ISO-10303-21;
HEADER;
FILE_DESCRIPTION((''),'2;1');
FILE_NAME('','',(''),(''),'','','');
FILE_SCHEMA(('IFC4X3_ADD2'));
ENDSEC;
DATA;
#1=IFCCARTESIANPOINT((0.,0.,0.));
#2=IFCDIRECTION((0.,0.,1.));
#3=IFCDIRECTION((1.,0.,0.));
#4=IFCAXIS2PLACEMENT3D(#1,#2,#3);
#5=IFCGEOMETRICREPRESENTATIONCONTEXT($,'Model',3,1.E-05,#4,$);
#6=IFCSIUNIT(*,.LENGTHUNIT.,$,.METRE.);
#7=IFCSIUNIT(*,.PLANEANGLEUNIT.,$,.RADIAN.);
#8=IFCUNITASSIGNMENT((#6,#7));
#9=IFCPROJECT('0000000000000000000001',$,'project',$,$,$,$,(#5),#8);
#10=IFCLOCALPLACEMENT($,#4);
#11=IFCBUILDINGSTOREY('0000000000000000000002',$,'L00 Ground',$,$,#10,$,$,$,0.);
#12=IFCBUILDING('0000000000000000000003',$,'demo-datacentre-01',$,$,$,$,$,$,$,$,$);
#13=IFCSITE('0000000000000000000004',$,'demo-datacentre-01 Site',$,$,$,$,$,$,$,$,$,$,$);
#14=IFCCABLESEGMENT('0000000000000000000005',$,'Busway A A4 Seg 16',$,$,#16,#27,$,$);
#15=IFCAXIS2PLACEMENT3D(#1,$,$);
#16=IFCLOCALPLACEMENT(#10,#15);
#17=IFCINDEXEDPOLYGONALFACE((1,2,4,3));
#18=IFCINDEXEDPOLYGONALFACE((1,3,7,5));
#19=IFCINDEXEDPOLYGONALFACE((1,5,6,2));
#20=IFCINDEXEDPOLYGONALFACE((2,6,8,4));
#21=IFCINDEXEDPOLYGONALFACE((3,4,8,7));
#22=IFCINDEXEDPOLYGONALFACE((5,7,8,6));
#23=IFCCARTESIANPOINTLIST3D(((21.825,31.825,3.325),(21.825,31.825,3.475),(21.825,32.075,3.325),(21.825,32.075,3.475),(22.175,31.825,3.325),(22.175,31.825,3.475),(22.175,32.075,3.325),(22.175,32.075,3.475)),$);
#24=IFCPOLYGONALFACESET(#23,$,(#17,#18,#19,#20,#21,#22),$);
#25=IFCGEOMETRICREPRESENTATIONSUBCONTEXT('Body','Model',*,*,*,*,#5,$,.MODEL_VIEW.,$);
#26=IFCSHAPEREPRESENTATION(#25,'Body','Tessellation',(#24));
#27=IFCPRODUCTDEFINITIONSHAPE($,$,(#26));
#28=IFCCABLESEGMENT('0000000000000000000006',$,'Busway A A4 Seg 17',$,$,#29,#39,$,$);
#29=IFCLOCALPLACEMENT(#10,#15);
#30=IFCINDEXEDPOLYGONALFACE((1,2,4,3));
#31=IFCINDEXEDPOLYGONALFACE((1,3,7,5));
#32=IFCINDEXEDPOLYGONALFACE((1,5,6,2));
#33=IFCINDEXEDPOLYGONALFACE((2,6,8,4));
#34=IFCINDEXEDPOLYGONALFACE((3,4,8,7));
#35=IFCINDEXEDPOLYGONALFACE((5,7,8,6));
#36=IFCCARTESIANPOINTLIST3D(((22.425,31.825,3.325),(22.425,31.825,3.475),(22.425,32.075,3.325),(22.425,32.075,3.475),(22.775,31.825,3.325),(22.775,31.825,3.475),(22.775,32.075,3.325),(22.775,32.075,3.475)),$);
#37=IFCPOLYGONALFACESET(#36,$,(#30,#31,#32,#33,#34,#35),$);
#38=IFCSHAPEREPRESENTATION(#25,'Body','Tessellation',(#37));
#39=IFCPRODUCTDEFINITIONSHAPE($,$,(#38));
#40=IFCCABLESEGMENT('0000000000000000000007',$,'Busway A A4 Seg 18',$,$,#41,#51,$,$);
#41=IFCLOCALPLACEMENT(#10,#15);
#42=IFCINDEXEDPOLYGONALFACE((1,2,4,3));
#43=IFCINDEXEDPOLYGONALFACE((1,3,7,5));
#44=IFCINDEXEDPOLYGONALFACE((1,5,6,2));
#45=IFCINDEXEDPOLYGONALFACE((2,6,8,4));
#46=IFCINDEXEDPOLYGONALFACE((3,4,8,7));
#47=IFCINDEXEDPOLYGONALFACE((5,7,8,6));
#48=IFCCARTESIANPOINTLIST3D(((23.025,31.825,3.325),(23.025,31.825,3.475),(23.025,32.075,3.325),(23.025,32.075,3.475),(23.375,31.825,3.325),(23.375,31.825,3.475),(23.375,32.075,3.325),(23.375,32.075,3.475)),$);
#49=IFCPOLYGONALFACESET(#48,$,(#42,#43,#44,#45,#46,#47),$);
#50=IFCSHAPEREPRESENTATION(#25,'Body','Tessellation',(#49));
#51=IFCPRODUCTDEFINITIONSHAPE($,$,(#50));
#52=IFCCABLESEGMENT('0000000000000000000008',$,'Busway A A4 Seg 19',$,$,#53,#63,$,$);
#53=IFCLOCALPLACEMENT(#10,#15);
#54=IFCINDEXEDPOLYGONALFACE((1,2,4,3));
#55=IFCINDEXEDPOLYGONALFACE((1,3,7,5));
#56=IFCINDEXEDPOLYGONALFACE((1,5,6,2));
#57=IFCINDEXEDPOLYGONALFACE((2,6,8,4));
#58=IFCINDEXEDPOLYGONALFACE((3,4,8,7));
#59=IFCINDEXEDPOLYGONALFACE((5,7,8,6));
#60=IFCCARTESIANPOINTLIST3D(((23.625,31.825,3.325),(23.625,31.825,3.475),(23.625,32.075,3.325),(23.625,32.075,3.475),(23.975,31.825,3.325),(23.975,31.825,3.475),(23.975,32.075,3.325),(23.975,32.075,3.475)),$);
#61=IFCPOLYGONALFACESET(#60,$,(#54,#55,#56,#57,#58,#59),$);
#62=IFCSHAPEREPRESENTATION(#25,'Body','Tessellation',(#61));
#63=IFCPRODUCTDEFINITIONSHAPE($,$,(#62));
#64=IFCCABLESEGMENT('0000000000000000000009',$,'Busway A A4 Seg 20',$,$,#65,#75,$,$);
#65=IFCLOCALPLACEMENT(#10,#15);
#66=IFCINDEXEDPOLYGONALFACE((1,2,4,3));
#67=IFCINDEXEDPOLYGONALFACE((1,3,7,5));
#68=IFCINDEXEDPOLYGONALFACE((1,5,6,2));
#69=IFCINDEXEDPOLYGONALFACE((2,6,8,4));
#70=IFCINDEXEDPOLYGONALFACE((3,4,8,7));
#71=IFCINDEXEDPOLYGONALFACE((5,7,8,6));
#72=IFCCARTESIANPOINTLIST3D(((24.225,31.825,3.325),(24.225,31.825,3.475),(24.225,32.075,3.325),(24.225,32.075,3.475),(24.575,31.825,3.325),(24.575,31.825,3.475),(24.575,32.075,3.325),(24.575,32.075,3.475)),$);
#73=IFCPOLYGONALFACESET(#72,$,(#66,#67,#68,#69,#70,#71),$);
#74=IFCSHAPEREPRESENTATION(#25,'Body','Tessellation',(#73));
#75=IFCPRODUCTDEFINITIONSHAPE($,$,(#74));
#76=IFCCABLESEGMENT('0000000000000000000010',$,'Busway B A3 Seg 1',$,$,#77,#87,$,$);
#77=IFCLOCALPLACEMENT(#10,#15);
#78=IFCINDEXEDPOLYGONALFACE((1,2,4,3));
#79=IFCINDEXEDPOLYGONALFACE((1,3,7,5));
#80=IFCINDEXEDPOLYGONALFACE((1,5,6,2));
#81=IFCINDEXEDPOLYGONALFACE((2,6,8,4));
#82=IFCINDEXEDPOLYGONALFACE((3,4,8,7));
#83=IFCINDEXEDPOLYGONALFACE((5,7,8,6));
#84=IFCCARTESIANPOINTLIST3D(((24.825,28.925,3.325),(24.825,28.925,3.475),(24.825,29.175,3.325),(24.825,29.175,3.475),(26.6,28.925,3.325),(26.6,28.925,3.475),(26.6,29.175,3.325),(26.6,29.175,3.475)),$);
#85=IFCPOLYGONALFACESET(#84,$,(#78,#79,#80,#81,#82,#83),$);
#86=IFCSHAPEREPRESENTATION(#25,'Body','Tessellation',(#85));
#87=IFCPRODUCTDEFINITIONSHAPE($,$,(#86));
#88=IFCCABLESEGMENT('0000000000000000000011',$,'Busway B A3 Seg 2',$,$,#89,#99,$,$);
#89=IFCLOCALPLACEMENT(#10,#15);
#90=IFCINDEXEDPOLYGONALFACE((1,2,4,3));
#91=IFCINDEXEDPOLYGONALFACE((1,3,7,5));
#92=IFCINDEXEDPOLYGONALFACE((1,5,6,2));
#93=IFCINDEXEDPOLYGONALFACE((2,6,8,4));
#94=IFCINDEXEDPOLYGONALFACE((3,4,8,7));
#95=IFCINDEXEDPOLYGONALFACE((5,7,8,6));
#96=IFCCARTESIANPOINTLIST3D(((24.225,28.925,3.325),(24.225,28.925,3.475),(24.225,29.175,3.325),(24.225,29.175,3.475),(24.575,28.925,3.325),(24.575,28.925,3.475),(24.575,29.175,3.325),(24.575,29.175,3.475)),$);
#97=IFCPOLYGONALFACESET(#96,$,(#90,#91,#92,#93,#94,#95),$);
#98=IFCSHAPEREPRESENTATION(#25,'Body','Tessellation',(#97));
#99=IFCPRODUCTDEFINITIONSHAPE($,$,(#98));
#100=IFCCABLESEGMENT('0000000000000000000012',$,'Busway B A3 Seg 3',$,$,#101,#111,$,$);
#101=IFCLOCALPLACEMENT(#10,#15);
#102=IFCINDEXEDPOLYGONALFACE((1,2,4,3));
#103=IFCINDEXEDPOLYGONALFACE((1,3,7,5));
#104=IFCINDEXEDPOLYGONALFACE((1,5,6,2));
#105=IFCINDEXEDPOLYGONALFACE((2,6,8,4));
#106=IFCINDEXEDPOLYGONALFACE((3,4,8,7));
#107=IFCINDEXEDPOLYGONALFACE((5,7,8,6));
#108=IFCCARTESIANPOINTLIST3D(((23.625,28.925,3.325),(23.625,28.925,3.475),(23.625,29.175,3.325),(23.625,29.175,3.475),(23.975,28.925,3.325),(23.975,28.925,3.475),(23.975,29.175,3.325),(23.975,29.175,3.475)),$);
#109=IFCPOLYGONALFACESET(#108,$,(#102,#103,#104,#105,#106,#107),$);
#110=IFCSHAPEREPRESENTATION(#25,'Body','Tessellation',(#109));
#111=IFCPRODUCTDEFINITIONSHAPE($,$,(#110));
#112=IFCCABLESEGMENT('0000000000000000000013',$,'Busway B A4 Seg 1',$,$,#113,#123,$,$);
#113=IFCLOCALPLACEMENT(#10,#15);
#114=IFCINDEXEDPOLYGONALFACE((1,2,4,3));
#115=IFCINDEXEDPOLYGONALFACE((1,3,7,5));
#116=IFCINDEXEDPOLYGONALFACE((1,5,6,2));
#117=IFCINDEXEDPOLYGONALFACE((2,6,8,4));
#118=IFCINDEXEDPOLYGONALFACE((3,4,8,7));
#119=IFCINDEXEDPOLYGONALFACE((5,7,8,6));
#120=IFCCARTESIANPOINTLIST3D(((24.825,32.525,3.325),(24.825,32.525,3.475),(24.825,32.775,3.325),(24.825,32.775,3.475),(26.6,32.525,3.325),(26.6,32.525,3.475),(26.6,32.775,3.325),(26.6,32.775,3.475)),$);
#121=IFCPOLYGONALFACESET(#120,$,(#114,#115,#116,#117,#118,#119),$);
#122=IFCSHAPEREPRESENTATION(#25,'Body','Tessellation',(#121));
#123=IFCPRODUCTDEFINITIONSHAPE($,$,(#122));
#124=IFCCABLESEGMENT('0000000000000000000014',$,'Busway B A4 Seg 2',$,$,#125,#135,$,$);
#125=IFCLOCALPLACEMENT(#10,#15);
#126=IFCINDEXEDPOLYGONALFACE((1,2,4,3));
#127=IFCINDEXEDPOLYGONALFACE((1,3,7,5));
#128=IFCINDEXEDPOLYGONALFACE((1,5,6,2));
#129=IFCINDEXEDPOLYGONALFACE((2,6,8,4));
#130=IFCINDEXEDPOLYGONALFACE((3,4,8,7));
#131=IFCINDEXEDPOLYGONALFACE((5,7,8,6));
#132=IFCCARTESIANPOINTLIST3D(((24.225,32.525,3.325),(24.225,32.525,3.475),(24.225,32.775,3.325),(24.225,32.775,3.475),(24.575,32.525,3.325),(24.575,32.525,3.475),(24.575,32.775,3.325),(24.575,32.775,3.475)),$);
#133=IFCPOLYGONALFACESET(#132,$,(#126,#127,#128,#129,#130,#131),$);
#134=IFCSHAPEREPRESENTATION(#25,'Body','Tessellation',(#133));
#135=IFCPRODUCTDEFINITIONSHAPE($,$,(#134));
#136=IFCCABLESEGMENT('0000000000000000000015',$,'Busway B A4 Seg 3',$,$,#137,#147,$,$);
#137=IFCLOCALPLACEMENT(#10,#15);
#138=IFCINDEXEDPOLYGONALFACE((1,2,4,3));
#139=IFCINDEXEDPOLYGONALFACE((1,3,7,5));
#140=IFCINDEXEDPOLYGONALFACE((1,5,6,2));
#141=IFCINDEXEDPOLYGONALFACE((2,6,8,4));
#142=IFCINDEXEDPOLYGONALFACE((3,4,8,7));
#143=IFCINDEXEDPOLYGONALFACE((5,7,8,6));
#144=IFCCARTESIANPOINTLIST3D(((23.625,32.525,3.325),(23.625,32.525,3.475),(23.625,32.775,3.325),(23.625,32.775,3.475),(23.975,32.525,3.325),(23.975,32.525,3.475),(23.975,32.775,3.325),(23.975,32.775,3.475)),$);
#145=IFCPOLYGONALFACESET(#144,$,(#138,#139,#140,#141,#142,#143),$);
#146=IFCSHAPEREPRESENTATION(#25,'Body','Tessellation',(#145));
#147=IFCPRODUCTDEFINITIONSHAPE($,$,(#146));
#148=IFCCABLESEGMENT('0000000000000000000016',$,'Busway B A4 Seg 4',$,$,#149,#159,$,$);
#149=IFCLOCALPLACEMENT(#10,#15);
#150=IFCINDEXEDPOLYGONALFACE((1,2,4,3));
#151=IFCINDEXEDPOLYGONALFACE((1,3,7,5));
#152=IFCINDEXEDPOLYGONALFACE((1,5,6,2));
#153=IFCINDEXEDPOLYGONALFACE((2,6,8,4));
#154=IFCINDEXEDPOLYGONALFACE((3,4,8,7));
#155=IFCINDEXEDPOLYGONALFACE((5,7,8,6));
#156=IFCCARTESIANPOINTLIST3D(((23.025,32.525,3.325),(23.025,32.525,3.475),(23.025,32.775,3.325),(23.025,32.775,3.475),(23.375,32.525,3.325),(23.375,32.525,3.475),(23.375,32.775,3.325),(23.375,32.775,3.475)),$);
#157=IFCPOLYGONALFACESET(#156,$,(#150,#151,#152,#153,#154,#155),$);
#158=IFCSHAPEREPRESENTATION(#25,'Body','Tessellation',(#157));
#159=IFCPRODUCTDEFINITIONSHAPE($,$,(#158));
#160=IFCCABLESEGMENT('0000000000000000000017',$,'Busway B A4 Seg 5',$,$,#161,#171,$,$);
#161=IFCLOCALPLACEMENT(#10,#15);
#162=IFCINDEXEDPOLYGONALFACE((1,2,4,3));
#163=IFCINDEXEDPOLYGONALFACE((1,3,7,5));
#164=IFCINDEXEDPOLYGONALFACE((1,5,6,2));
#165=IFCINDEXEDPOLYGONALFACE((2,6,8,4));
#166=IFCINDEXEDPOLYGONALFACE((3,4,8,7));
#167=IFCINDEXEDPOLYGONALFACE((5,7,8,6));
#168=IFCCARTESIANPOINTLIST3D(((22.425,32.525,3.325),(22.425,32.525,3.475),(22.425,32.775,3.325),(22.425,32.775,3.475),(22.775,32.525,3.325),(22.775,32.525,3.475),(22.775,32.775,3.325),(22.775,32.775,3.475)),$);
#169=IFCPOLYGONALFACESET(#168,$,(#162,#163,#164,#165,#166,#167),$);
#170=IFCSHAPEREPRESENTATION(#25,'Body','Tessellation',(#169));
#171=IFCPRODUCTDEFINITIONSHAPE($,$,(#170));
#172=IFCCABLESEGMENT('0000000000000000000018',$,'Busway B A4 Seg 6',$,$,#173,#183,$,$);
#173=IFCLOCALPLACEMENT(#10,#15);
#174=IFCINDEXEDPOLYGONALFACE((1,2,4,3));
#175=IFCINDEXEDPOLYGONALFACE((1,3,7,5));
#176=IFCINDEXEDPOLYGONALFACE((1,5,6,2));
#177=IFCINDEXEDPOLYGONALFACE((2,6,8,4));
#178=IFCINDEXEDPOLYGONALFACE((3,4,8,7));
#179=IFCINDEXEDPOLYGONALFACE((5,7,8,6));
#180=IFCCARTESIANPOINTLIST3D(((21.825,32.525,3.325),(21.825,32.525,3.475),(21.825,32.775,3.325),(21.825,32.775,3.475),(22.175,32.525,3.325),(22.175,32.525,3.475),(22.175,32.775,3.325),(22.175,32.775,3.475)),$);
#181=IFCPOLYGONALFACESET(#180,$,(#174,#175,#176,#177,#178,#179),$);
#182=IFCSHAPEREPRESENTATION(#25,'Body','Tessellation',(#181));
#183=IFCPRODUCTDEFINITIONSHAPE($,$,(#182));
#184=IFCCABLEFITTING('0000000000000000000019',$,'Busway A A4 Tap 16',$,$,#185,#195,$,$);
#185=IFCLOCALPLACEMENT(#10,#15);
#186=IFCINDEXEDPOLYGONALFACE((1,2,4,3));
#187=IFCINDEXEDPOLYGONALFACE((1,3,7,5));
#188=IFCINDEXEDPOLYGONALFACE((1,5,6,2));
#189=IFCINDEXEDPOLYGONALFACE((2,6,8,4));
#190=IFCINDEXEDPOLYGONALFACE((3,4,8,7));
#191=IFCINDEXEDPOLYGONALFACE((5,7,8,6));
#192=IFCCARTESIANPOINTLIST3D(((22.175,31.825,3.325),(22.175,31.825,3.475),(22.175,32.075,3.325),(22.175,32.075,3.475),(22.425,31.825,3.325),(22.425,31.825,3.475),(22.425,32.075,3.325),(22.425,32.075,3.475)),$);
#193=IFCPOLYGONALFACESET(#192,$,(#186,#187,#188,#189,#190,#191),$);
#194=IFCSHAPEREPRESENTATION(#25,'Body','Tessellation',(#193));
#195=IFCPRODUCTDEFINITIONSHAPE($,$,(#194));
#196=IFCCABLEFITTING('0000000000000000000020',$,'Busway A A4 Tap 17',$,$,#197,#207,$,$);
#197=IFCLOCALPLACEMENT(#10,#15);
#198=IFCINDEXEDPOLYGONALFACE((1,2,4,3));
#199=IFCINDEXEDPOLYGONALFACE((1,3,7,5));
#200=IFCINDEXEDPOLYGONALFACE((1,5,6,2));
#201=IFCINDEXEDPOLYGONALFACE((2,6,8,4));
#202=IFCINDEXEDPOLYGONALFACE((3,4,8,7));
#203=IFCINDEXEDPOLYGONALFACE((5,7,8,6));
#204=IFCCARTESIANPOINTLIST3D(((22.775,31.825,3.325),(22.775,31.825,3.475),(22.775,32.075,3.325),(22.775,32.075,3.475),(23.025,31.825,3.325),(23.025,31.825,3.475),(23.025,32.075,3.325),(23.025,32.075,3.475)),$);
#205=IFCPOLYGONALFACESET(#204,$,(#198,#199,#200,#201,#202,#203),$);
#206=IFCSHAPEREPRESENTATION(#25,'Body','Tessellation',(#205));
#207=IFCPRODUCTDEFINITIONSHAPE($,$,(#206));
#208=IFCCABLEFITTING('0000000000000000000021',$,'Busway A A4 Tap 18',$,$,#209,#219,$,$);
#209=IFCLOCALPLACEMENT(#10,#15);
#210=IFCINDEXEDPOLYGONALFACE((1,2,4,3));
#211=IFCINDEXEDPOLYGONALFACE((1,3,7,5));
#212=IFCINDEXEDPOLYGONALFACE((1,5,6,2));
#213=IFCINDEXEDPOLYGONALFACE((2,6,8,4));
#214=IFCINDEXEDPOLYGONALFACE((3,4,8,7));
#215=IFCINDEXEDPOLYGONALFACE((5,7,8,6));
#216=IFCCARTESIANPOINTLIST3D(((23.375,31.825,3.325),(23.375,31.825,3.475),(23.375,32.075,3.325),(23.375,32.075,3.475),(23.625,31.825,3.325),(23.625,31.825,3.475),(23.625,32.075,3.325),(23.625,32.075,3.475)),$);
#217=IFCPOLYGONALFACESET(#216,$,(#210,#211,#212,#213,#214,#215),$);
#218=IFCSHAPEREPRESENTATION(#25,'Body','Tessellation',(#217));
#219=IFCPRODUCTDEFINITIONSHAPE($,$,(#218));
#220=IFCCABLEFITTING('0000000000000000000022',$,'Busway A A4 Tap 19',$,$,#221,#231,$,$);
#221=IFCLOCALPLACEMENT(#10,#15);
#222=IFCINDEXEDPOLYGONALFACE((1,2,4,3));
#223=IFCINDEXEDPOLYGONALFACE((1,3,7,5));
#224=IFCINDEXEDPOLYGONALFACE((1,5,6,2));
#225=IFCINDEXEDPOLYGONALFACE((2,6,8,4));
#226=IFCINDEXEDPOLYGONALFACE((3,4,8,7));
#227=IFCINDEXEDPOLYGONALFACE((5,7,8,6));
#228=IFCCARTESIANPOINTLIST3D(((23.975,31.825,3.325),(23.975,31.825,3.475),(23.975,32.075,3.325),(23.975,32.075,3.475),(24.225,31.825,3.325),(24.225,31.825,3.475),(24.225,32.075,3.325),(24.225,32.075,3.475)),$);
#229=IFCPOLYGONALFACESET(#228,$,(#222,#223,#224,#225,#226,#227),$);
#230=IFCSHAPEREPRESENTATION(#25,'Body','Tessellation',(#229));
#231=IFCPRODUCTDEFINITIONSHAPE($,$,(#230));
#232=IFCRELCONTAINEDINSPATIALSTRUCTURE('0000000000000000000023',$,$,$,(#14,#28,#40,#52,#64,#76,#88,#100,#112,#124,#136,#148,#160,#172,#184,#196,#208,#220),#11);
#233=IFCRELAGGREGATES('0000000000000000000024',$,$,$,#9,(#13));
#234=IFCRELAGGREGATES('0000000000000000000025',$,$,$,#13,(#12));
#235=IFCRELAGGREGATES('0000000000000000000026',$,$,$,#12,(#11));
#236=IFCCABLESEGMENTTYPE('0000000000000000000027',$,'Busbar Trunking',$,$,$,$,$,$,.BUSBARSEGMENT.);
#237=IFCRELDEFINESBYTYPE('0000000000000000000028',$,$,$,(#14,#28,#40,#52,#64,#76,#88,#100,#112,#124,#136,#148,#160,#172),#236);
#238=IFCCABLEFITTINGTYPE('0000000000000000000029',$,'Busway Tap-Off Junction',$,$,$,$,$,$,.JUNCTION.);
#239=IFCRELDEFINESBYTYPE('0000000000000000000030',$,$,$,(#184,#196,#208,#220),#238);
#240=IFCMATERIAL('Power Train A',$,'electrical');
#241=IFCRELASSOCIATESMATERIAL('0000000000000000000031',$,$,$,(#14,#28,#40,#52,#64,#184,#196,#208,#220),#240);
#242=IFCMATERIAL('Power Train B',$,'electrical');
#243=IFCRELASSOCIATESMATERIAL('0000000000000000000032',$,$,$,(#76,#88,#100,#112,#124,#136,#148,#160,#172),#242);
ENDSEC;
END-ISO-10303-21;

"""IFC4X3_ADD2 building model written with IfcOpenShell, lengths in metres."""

from ifc_helpers import new_model, si_unit, frame, origin_with_axes, place, context, subcontext, project, spatial, rectangle, extrude, material, type_object, element, save


model = new_model("IFC4X3_ADD2")

# Units and contexts
model_context = context("Model", 3, precision=1e-05, world=origin_with_axes())
body_context = subcontext(model_context, "Body", "Model", "MODEL_VIEW")
ifc_project = project(units=[si_unit("LENGTHUNIT", "METRE"), si_unit("PLANEANGLEUNIT", "RADIAN")], contexts=[model_context])

# Site, building, storey
site = spatial("IfcSite", under=ifc_project, Name="demo-datacentre-01 Site")
building = spatial("IfcBuilding", under=site, Name="demo-datacentre-01")
storey_placement = place(None, origin_with_axes())
storey = spatial("IfcBuildingStorey", under=building, at=storey_placement, Name="L00 Ground", Elevation=0.0)

# Shared definitions
ifc_material_1 = material(Name="Power Train B", Category="electrical")

# Cable segments
ifc_material_2 = material(Name="Power Train A", Category="electrical")
cable_segment_type_1 = type_object("IfcCableSegmentType", Name="Busbar Trunking", PredefinedType="BUSBARSEGMENT")
for number, where, z_axis, x_axis, name in (
    (1, (21.825, 31.95, 3.4), (1.0, 0.0, 0.0), (0.0, 1.0, 0.0), "Busway A A4 Seg 16"),
    (2, (22.425, 31.95, 3.4), (1.0, 0.0, 0.0), (0.0, 1.0, 0.0), "Busway A A4 Seg 17"),
):
    element("IfcCableSegment", number, at=place(storey_placement, frame(where, z_axis=z_axis, x_axis=x_axis)), inside=storey, type_object=cable_segment_type_1, material=ifc_material_2, Name=name, context=body_context, shape_type="SweptSolid", body=[
        extrude(rectangle(XDim=0.25, YDim=0.15), origin_with_axes(), (0.0, 0.0, 1.0), 0.35),
    ])
for number, where, z_axis, x_axis, name in (
    (3, (23.025, 31.95, 3.4), (1.0, 0.0, 0.0), (0.0, 1.0, 0.0), "Busway A A4 Seg 18"),
    (4, (23.625, 31.95, 3.4), (1.0, 0.0, 0.0), (0.0, 1.0, 0.0), "Busway A A4 Seg 19"),
    (5, (24.225, 31.95, 3.4), (1.0, 0.0, 0.0), (0.0, 1.0, 0.0), "Busway A A4 Seg 20"),
):
    element("IfcCableSegment", number, at=place(storey_placement, frame(where, z_axis=z_axis, x_axis=x_axis)), inside=storey, type_object=cable_segment_type_1, material=ifc_material_2, Name=name, context=body_context, shape_type="SweptSolid", body=[
        extrude(rectangle(XDim=0.25, YDim=0.15), origin_with_axes(), (0.0, 0.0, 1.0), 0.35),
    ])
cable_segment_1_placement = place(storey_placement, frame((26.6, 29.05, 3.4), z_axis=(-1.0, 0.0, 0.0), x_axis=(0.0, -1.0, 0.0)))
element("IfcCableSegment", 6, at=cable_segment_1_placement, inside=storey, type_object=cable_segment_type_1, material=ifc_material_1, Name="Busway B A3 Seg 1", context=body_context, shape_type="SweptSolid", body=[
    extrude(rectangle(XDim=0.25, YDim=0.15), origin_with_axes(), (0.0, 0.0, 1.0), 1.775),
])
for number, where, z_axis, x_axis, name in (
    (7, (24.575, 29.05, 3.4), (-1.0, 0.0, 0.0), (0.0, -1.0, 0.0), "Busway B A3 Seg 2"),
    (8, (23.975, 29.05, 3.4), (-1.0, 0.0, 0.0), (0.0, -1.0, 0.0), "Busway B A3 Seg 3"),
):
    element("IfcCableSegment", number, at=place(storey_placement, frame(where, z_axis=z_axis, x_axis=x_axis)), inside=storey, type_object=cable_segment_type_1, material=ifc_material_1, Name=name, context=body_context, shape_type="SweptSolid", body=[
        extrude(rectangle(XDim=0.25, YDim=0.15), origin_with_axes(), (0.0, 0.0, 1.0), 0.35),
    ])
cable_segment_2_placement = place(storey_placement, frame((26.6, 32.65, 3.4), z_axis=(-1.0, 0.0, 0.0), x_axis=(0.0, -1.0, 0.0)))
element("IfcCableSegment", 9, at=cable_segment_2_placement, inside=storey, type_object=cable_segment_type_1, material=ifc_material_1, Name="Busway B A4 Seg 1", context=body_context, shape_type="SweptSolid", body=[
    extrude(rectangle(XDim=0.25, YDim=0.15), origin_with_axes(), (0.0, 0.0, 1.0), 1.775),
])
for number, where, z_axis, x_axis, name in (
    (10, (24.575, 32.65, 3.4), (-1.0, 0.0, 0.0), (0.0, -1.0, 0.0), "Busway B A4 Seg 2"),
    (11, (23.975, 32.65, 3.4), (-1.0, 0.0, 0.0), (0.0, -1.0, 0.0), "Busway B A4 Seg 3"),
    (12, (23.375, 32.65, 3.4), (-1.0, 0.0, 0.0), (0.0, -1.0, 0.0), "Busway B A4 Seg 4"),
):
    element("IfcCableSegment", number, at=place(storey_placement, frame(where, z_axis=z_axis, x_axis=x_axis)), inside=storey, type_object=cable_segment_type_1, material=ifc_material_1, Name=name, context=body_context, shape_type="SweptSolid", body=[
        extrude(rectangle(XDim=0.25, YDim=0.15), origin_with_axes(), (0.0, 0.0, 1.0), 0.35),
    ])
for number, where, z_axis, x_axis, name in (
    (13, (22.775, 32.65, 3.4), (-1.0, 0.0, 0.0), (0.0, -1.0, 0.0), "Busway B A4 Seg 5"),
    (14, (22.175, 32.65, 3.4), (-1.0, 0.0, 0.0), (0.0, -1.0, 0.0), "Busway B A4 Seg 6"),
):
    element("IfcCableSegment", number, at=place(storey_placement, frame(where, z_axis=z_axis, x_axis=x_axis)), inside=storey, type_object=cable_segment_type_1, material=ifc_material_1, Name=name, context=body_context, shape_type="SweptSolid", body=[
        extrude(rectangle(XDim=0.25, YDim=0.15), origin_with_axes(), (0.0, 0.0, 1.0), 0.35),
    ])

# Cable fittings
cable_fitting_type = type_object("IfcCableFittingType", Name="Busway Tap-Off Junction", PredefinedType="JUNCTION")
for number, where, z_axis, x_axis, name in (
    (15, (22.3, 31.95, 3.325), (0.0, 0.0, 1.0), (1.0, 0.0, 0.0), "Busway A A4 Tap 16"),
    (16, (22.9, 31.95, 3.325), (0.0, 0.0, 1.0), (1.0, 0.0, 0.0), "Busway A A4 Tap 17"),
    (17, (23.5, 31.95, 3.325), (0.0, 0.0, 1.0), (1.0, 0.0, 0.0), "Busway A A4 Tap 18"),
    (18, (24.1, 31.95, 3.325), (0.0, 0.0, 1.0), (1.0, 0.0, 0.0), "Busway A A4 Tap 19"),
):
    element("IfcCableFitting", number, at=place(storey_placement, frame(where, z_axis=z_axis, x_axis=x_axis)), inside=storey, type_object=cable_fitting_type, material=ifc_material_2, Name=name, context=body_context, shape_type="SweptSolid", body=[
        extrude(rectangle(XDim=0.25, YDim=0.25), origin_with_axes(), (0.0, 0.0, 1.0), 0.15),
    ])

save(model, "model.ifc")
